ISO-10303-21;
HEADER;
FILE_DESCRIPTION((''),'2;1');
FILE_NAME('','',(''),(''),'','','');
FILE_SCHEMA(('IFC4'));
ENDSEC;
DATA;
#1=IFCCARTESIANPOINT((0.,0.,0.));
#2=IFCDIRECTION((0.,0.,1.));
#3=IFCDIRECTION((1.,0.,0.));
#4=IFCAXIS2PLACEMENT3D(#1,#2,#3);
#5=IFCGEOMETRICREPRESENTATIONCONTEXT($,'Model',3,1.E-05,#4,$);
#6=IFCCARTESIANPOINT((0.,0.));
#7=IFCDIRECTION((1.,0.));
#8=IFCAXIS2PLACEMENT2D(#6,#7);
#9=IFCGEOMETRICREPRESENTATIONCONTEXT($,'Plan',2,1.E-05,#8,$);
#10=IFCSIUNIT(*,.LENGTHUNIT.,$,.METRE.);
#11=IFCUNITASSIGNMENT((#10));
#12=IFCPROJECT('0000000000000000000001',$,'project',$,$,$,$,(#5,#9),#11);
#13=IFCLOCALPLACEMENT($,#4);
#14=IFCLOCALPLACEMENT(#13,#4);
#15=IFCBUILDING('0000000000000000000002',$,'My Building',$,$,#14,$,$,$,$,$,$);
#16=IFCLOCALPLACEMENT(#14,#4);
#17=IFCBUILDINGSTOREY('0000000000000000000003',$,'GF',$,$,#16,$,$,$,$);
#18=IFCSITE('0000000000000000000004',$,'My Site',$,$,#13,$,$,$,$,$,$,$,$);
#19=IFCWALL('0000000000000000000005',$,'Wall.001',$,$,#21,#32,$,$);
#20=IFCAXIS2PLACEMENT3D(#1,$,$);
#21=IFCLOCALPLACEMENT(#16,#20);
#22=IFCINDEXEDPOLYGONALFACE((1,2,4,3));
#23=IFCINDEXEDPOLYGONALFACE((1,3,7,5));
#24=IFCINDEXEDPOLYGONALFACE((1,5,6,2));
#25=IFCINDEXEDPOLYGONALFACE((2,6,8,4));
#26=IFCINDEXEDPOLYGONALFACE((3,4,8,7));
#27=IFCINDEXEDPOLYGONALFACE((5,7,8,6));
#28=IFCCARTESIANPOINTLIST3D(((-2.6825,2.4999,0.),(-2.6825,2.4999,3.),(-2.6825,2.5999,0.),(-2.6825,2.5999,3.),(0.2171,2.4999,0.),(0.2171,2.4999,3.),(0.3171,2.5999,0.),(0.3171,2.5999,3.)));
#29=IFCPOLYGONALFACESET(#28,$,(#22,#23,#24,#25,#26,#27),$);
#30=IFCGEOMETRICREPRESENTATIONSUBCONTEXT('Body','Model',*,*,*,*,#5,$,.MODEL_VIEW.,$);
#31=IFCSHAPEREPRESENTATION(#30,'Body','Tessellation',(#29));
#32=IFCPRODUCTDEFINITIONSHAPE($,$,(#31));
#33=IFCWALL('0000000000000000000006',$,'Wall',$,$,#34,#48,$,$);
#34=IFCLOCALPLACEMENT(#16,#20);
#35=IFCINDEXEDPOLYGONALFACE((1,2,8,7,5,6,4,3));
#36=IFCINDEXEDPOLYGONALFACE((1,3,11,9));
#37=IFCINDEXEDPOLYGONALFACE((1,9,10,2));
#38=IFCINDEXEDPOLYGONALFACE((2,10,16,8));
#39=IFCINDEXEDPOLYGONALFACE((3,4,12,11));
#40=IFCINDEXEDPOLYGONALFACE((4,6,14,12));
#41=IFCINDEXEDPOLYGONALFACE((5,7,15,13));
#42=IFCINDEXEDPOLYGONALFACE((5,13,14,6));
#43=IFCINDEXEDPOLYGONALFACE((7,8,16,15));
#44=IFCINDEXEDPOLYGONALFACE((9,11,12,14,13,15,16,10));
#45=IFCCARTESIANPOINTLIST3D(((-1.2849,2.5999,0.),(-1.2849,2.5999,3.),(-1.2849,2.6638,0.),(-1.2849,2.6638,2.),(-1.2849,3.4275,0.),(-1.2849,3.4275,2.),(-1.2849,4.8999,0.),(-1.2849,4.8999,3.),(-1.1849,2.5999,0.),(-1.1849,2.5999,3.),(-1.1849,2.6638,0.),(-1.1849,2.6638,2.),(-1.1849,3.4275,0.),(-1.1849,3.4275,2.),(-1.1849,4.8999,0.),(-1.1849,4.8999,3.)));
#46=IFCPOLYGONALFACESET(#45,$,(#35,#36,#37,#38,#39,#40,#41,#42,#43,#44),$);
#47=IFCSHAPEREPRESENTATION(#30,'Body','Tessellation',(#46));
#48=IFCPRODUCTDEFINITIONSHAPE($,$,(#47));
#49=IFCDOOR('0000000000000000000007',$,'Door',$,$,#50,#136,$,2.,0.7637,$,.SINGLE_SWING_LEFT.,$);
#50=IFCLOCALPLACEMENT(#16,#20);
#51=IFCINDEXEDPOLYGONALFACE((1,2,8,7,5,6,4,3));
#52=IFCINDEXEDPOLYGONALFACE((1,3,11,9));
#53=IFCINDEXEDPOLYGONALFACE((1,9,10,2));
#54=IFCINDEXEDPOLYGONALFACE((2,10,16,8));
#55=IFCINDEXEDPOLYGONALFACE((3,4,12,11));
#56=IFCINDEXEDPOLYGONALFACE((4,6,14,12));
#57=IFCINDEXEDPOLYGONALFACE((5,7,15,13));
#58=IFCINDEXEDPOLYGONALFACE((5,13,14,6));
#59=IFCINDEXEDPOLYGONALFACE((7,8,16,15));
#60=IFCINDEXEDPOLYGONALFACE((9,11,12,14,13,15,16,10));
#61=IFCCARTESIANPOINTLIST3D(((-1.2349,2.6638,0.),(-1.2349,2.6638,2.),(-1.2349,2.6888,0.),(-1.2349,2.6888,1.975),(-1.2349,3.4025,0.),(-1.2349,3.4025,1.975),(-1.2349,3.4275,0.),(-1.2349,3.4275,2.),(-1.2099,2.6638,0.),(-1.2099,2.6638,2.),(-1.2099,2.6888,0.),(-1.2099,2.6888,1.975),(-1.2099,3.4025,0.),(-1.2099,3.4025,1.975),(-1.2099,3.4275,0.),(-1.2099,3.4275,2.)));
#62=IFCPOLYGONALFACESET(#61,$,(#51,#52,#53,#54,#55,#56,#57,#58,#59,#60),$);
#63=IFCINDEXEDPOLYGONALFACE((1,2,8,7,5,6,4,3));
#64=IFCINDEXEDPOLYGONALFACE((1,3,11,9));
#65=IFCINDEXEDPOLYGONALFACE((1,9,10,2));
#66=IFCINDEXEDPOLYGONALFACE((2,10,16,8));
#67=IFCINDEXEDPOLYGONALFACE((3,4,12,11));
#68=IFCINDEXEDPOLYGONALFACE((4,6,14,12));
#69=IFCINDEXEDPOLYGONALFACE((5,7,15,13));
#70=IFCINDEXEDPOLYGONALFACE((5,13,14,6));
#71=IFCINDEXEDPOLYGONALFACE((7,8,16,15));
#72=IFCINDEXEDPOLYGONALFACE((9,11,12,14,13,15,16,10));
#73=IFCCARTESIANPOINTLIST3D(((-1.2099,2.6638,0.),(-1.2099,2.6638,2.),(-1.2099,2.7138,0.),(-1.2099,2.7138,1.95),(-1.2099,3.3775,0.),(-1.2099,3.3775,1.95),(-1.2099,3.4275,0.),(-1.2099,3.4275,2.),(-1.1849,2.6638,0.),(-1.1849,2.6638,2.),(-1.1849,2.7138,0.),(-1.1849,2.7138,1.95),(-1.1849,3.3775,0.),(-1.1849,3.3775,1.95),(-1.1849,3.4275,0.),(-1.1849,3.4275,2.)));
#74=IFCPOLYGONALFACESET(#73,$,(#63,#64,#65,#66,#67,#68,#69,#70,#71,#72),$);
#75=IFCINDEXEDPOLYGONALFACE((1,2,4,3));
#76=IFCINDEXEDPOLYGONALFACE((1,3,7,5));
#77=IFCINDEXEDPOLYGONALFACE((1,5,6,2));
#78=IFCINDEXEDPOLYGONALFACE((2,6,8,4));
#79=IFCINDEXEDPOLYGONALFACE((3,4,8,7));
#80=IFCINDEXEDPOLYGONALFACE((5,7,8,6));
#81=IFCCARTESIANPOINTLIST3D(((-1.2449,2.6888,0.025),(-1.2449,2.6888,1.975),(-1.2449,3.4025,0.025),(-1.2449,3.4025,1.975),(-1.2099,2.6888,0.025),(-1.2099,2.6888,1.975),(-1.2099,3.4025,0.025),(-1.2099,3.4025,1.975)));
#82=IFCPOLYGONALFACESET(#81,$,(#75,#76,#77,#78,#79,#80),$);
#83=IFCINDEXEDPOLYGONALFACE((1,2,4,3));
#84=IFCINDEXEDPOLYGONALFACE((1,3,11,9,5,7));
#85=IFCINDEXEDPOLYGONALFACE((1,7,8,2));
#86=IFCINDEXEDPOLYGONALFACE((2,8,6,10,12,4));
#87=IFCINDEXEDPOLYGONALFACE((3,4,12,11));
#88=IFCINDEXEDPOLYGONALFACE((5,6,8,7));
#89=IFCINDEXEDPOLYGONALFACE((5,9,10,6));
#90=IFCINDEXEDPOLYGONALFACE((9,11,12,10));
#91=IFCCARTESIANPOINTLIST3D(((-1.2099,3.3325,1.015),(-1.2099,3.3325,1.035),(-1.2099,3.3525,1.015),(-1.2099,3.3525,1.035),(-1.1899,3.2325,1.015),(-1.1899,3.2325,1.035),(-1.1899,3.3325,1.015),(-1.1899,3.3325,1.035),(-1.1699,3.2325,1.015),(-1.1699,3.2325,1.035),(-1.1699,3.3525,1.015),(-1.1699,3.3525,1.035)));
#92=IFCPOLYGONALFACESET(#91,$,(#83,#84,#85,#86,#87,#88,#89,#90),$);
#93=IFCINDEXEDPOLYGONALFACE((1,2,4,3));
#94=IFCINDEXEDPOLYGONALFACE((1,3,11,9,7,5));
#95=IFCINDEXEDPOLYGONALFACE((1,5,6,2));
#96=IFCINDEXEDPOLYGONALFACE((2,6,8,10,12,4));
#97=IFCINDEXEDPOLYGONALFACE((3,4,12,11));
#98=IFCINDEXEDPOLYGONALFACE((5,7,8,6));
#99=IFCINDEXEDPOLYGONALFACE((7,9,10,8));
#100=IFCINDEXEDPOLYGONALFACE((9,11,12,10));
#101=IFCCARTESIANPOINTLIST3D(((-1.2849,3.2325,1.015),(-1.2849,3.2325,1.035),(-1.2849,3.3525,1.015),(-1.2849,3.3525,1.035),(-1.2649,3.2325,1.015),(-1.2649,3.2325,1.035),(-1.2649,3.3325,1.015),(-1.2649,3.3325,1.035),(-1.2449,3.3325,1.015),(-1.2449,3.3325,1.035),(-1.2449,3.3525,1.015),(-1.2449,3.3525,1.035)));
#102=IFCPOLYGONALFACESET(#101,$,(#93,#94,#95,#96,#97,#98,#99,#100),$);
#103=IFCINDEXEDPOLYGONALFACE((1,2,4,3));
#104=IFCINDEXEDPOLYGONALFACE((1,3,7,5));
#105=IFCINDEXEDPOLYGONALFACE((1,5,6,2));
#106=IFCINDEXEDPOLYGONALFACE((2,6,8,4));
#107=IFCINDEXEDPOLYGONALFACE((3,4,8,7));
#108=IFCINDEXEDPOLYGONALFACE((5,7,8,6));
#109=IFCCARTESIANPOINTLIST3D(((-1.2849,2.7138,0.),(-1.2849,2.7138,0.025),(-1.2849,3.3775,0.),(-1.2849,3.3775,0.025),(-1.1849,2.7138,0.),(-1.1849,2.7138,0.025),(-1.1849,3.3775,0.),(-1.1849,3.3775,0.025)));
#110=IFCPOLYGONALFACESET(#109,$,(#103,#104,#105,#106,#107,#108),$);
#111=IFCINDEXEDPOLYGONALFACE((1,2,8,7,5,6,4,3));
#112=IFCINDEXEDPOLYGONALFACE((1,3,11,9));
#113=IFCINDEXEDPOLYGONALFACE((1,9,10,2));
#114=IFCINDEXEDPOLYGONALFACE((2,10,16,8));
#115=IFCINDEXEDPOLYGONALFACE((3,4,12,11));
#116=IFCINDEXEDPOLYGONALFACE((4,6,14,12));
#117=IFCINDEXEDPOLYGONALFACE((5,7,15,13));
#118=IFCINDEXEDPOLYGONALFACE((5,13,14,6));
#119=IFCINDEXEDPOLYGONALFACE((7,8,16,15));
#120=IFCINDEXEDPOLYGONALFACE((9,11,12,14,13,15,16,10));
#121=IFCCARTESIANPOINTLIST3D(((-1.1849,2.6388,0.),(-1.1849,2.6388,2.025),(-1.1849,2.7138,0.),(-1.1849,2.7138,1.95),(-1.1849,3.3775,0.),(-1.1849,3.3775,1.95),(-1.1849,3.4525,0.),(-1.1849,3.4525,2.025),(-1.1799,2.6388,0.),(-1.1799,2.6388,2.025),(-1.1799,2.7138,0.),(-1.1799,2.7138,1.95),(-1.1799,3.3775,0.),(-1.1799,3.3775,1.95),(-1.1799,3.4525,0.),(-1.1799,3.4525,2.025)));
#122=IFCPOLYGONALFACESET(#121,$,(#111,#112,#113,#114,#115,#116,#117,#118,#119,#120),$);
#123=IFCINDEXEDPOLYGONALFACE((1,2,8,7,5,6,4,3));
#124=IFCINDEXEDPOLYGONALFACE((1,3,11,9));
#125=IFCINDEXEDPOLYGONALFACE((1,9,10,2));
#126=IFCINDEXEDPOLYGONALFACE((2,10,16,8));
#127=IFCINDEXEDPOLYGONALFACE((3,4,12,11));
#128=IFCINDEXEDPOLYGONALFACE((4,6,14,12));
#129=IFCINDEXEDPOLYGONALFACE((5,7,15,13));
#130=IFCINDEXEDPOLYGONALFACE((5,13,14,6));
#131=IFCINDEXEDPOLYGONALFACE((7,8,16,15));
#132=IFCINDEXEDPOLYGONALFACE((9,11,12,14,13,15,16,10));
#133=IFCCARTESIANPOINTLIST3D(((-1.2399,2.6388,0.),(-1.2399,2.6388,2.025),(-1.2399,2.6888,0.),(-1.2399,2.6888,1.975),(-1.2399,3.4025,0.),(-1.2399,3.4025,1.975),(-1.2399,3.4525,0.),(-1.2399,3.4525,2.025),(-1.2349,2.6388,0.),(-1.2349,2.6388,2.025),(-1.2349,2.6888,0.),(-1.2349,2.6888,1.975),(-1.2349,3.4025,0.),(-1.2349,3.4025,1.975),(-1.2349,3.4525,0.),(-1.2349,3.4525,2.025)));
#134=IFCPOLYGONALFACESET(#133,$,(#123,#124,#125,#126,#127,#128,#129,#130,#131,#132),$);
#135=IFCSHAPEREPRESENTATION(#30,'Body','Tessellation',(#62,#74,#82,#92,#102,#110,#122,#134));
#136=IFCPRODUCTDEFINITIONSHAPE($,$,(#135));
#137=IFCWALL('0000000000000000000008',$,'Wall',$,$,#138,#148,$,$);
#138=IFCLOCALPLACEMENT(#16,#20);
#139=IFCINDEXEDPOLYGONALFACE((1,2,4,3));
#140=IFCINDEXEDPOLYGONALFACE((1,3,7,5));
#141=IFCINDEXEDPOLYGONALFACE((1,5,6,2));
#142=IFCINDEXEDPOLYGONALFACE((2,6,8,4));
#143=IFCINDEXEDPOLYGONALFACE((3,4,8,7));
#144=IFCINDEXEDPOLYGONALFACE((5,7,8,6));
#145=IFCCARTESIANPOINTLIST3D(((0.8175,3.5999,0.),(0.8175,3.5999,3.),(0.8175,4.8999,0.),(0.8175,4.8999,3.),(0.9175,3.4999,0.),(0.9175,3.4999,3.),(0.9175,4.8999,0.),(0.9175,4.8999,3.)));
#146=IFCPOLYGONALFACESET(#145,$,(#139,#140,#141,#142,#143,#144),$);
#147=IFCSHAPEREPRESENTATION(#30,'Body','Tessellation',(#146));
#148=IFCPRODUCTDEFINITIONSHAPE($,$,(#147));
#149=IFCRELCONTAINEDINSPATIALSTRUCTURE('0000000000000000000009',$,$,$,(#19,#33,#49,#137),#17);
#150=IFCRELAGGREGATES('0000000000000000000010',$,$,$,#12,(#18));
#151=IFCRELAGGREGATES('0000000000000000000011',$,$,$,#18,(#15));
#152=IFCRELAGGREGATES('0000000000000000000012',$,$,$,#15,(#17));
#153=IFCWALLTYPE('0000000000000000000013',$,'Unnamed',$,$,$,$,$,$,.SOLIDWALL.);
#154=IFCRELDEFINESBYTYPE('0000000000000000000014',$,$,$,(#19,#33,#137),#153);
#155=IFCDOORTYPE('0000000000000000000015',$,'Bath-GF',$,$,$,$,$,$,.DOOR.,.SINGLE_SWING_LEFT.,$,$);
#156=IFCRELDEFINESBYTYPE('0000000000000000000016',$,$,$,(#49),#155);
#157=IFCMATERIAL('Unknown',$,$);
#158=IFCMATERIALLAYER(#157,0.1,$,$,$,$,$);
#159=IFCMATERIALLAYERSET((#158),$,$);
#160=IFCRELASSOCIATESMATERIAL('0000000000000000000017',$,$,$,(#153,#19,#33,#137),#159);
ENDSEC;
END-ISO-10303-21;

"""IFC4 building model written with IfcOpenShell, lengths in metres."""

from ifc_helpers import new_model, entity, si_unit, frame, origin_with_axes, origin_2d_with_axis, place, context, subcontext, project, spatial, line, indexed_curve, outline, extrude, shape, source, transform, mapped, material, layer, layer_set, layer_usage, type_object, type_shapes, element, fill, save


model = new_model("IFC4")

# Units and contexts
model_context = context("Model", 3, precision=1e-05, world=origin_with_axes())
plan_context = context("Plan", 2, precision=1e-05, world=origin_2d_with_axis())
body_context_1 = subcontext(model_context, "Body", "Model", "MODEL_VIEW")
body_context_2 = subcontext(plan_context, "Body", "Plan", "PLAN_VIEW")
ifc_project = project(units=[si_unit("LENGTHUNIT", "METRE")], contexts=[model_context, plan_context])

# Site, building, storey
site_placement = place(None, origin_with_axes())
site = spatial("IfcSite", under=ifc_project, at=site_placement, Name="My Site")
building_placement = place(site_placement, origin_with_axes())
building = spatial("IfcBuilding", under=site, at=building_placement, Name="My Building")
storey_placement = place(building_placement, origin_with_axes())
storey = spatial("IfcBuildingStorey", under=building, at=storey_placement, Name="GF")

# Shared definitions
ifc_material = material(Name="Unknown")

# Shared definitions
ifc_layer_1 = layer(ifc_material, 0.1)
ifc_layer_set_1 = layer_set([ifc_layer_1])
wall_type = type_object("IfcWallType", Name="Unnamed", PredefinedType="SOLIDWALL", material=ifc_layer_set_1)

# Wall
ifc_layer_usage_1 = layer_usage(ifc_layer_set_1, "AXIS2", "POSITIVE", 0.0)
wall_1_placement = place(storey_placement, frame((0.3171, 2.5999, 0.0), z_axis=(0.0, 0.0, 1.0), x_axis=(-1.0, 0.0, 0.0)))
element("IfcWall", 1, at=wall_1_placement, inside=storey, type_object=wall_type, material=ifc_layer_usage_1, Name="Wall.001", context=body_context_1, shape_type="SweptSolid", body=[
    extrude(outline(indexed_curve([(0.0, 0.0), (0.1, 0.1), (2.9996, 0.1), (2.9996, 0.0)], segments=[line(1, 2, 3, 4, 1)])), origin_with_axes(), (0.0, 0.0, 1.0), 3.0),
])

# Wall, opening, door
ifc_layer_usage_2 = layer_usage(ifc_layer_set_1, "AXIS2", "POSITIVE", 0.0)
wall_2_placement = place(storey_placement, frame((-1.1849, 2.5999, 0.0), z_axis=(0.0, 0.0, 1.0), x_axis=(0.0, 1.0, 0.0)))
wall_2 = element("IfcWall", 2, at=wall_2_placement, inside=storey, type_object=wall_type, material=ifc_layer_usage_2, Name="Wall", context=body_context_1, shape_type="SweptSolid", body=[
    extrude(outline(indexed_curve([(0.0, 0.0), (0.0, 0.1), (2.3, 0.1), (2.3, 0.0)], segments=[line(1, 2, 3, 4, 1)])), origin_with_axes(), (0.0, 0.0, 1.0), 3.0),
])
shared_shape_1 = source(origin_with_axes(), body_context_1, "Body", "SweptSolid", [
    extrude(outline(indexed_curve([(0.0, 0.0), (0.7637, 0.0), (0.7637, 2.0), (0.0, 2.0)], segments=[line(1, 2, 3, 4, 1)])), frame((0.0, -0.6, 0.0), z_axis=(0.0, -1.0, 0.0), x_axis=(1.0, 0.0, 0.0)), (0.0, 0.0, -1.0), 1.2),
])
opening_1_placement = place(wall_2_placement, frame((0.0639, 0.0, 0.0), z_axis=(0.0, 0.0, 1.0), x_axis=(1.0, 0.0, 0.0)))
opening_1 = element("IfcOpeningElement", 3, at=opening_1_placement, cuts=wall_2, PredefinedType="OPENING", context=body_context_1, shape_type="MappedRepresentation", body=[
    mapped(shared_shape_1, transform((0.0, 0.0, 0.0), x_axis=(1.0, 0.0, 0.0), y_axis=(0.0, 1.0, 0.0), z_axis=(0.0, 0.0, 1.0), scale=1.0)),
])
door_type_1 = type_object("IfcDoorType", Name="Bath-GF", OperationType="SINGLE_SWING_LEFT", PredefinedType="DOOR")
shared_shape_2 = source(origin_with_axes(), body_context_1, "Body", "SweptSolid", [
    extrude(outline(indexed_curve([(0.0, 0.0), (0.0, 2.0), (0.7637, 2.0), (0.7637, 0.0), (0.7387, 0.0), (0.7387, 1.975), (0.025, 1.975), (0.025, 0.0)], segments=[line(1, 2, 3, 4, 5, 6, 7, 8, 1)])), frame((0.0, 0.025, 0.0), z_axis=(0.0, -1.0, 0.0), x_axis=(1.0, 0.0, 0.0)), (0.0, 0.0, -1.0), 0.025),
    extrude(outline(indexed_curve([(0.0, 0.0), (0.0, 2.0), (0.7637, 2.0), (0.7637, 0.0), (0.7137, 0.0), (0.7137, 1.95), (0.05, 1.95), (0.05, 0.0)], segments=[line(1, 2, 3, 4, 5, 6, 7, 8, 1)])), frame((0.0, 0.0, 0.0), z_axis=(0.0, -1.0, 0.0), x_axis=(1.0, 0.0, 0.0)), (0.0, 0.0, -1.0), 0.025),
    extrude(outline(indexed_curve([(0.0, 0.0), (0.7137, 0.0), (0.7137, 0.035), (0.0, 0.035)], segments=[line(1, 2, 3, 4, 1)])), frame((0.025, 0.025, 0.025), z_axis=(0.0, 0.0, 1.0), x_axis=(1.0, 0.0, 0.0)), (0.0, 0.0, 1.0), 1.95),
    extrude(outline(indexed_curve([(0.0, 0.0), (0.0, -0.04), (-0.12, -0.04), (-0.12, -0.02), (-0.02, -0.02), (-0.02, 0.0)], segments=[line(1, 2, 3, 4, 5, 6, 1)])), frame((0.6887, 0.025, 1.015), z_axis=(0.0, 0.0, 1.0), x_axis=(1.0, 0.0, 0.0)), (0.0, 0.0, 1.0), 0.02),
    extrude(outline(indexed_curve([(0.0, 0.0), (0.0, 0.04), (-0.12, 0.04), (-0.12, 0.02), (-0.02, 0.02), (-0.02, 0.0)], segments=[line(1, 2, 3, 4, 5, 6, 1)])), frame((0.6887, 0.06, 1.015), z_axis=(0.0, 0.0, 1.0), x_axis=(1.0, 0.0, 0.0)), (0.0, 0.0, 1.0), 0.02),
    extrude(outline(indexed_curve([(0.0, 0.0), (0.6637, 0.0), (0.6637, 0.1), (0.0, 0.1)], segments=[line(1, 2, 3, 4, 1)])), frame((0.05, 0.0, 0.0), z_axis=(0.0, 0.0, 1.0), x_axis=(1.0, 0.0, 0.0)), (0.0, 0.0, 1.0), 0.025),
    extrude(outline(indexed_curve([(0.0, 0.0), (0.0, 2.025), (0.8137, 2.025), (0.8137, 0.0), (0.7387, 0.0), (0.7387, 1.95), (0.075, 1.95), (0.075, 0.0)], segments=[line(1, 2, 3, 4, 5, 6, 7, 8, 1)])), frame((-0.025, -0.005, 0.0), z_axis=(0.0, -1.0, 0.0), x_axis=(1.0, 0.0, 0.0)), (0.0, 0.0, -1.0), 0.005),
    extrude(outline(indexed_curve([(0.0, 0.0), (0.0, 2.025), (0.8137, 2.025), (0.8137, 0.0), (0.7637, 0.0), (0.7637, 1.975), (0.05, 1.975), (0.05, 0.0)], segments=[line(1, 2, 3, 4, 5, 6, 7, 8, 1)])), frame((-0.025, 0.05, 0.0), z_axis=(0.0, -1.0, 0.0), x_axis=(1.0, 0.0, 0.0)), (0.0, 0.0, -1.0), 0.005),
])
shared_shape_3 = source(origin_with_axes(), body_context_2, "Body", "Curve2D", [
    entity("IfcIndexedPolyCurve", entity("IfcCartesianPointList2D", [[0.0, 0.0], [0.0, 0.05], [0.025, 0.05], [0.025, 0.025], [0.05, 0.025], [0.05, 0.0]]), [entity("IfcLineIndex", [1, 2, 3, 4, 5, 6, 1])]),
    entity("IfcIndexedPolyCurve", entity("IfcCartesianPointList2D", [[0.7637, 0.0], [0.7637, 0.05], [0.7387, 0.05], [0.7387, 0.025], [0.7137, 0.025], [0.7137, 0.0]]), [entity("IfcLineIndex", [1, 2, 3, 4, 5, 6, 1])]),
    entity("IfcTrimmedCurve", entity("IfcEllipse", entity("IfcAxis2Placement2D", entity("IfcCartesianPoint", [0.06, 0.05]), entity("IfcDirection", [1.0, 0.0])), 0.6787, 0.7137), [entity("IfcCartesianPoint", [0.7387, 0.05])], [entity("IfcCartesianPoint", [0.06, 0.7637])], True, "CARTESIAN"),
    entity("IfcIndexedPolyCurve", entity("IfcCartesianPointList2D", [[0.025, 0.05], [0.06, 0.05], [0.06, 0.7637], [0.025, 0.7637]]), [entity("IfcLineIndex", [1, 2, 3, 4, 1])]),
])
type_shapes(door_type_1, [shared_shape_2, shared_shape_3])
door_1_placement = place(opening_1_placement, frame((0.0, 0.0, 0.0), z_axis=(0.0, 0.0, 1.0), x_axis=(1.0, 0.0, 0.0)))
door_1 = element("IfcDoor", 4, at=door_1_placement, inside=storey, type_object=door_type_1, Name="Door", OperationType="SINGLE_SWING_LEFT", OverallHeight=2.0, OverallWidth=0.7637, shapes=[
    shape(body_context_1, "Body", "MappedRepresentation", [mapped(shared_shape_2, transform((0.0, 0.0, 0.0), x_axis=(1.0, 0.0, 0.0), y_axis=(0.0, 1.0, 0.0), z_axis=(0.0, 0.0, 1.0), scale=1.0))]),
    shape(body_context_2, "Body", "MappedRepresentation", [mapped(shared_shape_3, transform((0.0, 0.0, 0.0), x_axis=(1.0, 0.0, 0.0), y_axis=(0.0, 1.0, 0.0), z_axis=(0.0, 0.0, 1.0), scale=1.0))]),
])
fill(opening_1, door_1)

# Wall
ifc_layer_usage_3 = layer_usage(ifc_layer_set_1, "AXIS2", "POSITIVE", 0.0)
wall_3_placement = place(storey_placement, frame((0.8175, 4.8999, 0.0), z_axis=(0.0, 0.0, 1.0), x_axis=(0.0, -1.0, 0.0)))
element("IfcWall", 5, at=wall_3_placement, inside=storey, type_object=wall_type, material=ifc_layer_usage_3, Name="Wall", context=body_context_1, shape_type="SweptSolid", body=[
    extrude(outline(indexed_curve([(0.0, 0.0), (0.0, 0.1), (1.4, 0.1), (1.3, 0.0)], segments=[line(1, 2, 3, 4, 1)])), origin_with_axes(), (0.0, 0.0, 1.0), 3.0),
])

save(model, "model.ifc")
